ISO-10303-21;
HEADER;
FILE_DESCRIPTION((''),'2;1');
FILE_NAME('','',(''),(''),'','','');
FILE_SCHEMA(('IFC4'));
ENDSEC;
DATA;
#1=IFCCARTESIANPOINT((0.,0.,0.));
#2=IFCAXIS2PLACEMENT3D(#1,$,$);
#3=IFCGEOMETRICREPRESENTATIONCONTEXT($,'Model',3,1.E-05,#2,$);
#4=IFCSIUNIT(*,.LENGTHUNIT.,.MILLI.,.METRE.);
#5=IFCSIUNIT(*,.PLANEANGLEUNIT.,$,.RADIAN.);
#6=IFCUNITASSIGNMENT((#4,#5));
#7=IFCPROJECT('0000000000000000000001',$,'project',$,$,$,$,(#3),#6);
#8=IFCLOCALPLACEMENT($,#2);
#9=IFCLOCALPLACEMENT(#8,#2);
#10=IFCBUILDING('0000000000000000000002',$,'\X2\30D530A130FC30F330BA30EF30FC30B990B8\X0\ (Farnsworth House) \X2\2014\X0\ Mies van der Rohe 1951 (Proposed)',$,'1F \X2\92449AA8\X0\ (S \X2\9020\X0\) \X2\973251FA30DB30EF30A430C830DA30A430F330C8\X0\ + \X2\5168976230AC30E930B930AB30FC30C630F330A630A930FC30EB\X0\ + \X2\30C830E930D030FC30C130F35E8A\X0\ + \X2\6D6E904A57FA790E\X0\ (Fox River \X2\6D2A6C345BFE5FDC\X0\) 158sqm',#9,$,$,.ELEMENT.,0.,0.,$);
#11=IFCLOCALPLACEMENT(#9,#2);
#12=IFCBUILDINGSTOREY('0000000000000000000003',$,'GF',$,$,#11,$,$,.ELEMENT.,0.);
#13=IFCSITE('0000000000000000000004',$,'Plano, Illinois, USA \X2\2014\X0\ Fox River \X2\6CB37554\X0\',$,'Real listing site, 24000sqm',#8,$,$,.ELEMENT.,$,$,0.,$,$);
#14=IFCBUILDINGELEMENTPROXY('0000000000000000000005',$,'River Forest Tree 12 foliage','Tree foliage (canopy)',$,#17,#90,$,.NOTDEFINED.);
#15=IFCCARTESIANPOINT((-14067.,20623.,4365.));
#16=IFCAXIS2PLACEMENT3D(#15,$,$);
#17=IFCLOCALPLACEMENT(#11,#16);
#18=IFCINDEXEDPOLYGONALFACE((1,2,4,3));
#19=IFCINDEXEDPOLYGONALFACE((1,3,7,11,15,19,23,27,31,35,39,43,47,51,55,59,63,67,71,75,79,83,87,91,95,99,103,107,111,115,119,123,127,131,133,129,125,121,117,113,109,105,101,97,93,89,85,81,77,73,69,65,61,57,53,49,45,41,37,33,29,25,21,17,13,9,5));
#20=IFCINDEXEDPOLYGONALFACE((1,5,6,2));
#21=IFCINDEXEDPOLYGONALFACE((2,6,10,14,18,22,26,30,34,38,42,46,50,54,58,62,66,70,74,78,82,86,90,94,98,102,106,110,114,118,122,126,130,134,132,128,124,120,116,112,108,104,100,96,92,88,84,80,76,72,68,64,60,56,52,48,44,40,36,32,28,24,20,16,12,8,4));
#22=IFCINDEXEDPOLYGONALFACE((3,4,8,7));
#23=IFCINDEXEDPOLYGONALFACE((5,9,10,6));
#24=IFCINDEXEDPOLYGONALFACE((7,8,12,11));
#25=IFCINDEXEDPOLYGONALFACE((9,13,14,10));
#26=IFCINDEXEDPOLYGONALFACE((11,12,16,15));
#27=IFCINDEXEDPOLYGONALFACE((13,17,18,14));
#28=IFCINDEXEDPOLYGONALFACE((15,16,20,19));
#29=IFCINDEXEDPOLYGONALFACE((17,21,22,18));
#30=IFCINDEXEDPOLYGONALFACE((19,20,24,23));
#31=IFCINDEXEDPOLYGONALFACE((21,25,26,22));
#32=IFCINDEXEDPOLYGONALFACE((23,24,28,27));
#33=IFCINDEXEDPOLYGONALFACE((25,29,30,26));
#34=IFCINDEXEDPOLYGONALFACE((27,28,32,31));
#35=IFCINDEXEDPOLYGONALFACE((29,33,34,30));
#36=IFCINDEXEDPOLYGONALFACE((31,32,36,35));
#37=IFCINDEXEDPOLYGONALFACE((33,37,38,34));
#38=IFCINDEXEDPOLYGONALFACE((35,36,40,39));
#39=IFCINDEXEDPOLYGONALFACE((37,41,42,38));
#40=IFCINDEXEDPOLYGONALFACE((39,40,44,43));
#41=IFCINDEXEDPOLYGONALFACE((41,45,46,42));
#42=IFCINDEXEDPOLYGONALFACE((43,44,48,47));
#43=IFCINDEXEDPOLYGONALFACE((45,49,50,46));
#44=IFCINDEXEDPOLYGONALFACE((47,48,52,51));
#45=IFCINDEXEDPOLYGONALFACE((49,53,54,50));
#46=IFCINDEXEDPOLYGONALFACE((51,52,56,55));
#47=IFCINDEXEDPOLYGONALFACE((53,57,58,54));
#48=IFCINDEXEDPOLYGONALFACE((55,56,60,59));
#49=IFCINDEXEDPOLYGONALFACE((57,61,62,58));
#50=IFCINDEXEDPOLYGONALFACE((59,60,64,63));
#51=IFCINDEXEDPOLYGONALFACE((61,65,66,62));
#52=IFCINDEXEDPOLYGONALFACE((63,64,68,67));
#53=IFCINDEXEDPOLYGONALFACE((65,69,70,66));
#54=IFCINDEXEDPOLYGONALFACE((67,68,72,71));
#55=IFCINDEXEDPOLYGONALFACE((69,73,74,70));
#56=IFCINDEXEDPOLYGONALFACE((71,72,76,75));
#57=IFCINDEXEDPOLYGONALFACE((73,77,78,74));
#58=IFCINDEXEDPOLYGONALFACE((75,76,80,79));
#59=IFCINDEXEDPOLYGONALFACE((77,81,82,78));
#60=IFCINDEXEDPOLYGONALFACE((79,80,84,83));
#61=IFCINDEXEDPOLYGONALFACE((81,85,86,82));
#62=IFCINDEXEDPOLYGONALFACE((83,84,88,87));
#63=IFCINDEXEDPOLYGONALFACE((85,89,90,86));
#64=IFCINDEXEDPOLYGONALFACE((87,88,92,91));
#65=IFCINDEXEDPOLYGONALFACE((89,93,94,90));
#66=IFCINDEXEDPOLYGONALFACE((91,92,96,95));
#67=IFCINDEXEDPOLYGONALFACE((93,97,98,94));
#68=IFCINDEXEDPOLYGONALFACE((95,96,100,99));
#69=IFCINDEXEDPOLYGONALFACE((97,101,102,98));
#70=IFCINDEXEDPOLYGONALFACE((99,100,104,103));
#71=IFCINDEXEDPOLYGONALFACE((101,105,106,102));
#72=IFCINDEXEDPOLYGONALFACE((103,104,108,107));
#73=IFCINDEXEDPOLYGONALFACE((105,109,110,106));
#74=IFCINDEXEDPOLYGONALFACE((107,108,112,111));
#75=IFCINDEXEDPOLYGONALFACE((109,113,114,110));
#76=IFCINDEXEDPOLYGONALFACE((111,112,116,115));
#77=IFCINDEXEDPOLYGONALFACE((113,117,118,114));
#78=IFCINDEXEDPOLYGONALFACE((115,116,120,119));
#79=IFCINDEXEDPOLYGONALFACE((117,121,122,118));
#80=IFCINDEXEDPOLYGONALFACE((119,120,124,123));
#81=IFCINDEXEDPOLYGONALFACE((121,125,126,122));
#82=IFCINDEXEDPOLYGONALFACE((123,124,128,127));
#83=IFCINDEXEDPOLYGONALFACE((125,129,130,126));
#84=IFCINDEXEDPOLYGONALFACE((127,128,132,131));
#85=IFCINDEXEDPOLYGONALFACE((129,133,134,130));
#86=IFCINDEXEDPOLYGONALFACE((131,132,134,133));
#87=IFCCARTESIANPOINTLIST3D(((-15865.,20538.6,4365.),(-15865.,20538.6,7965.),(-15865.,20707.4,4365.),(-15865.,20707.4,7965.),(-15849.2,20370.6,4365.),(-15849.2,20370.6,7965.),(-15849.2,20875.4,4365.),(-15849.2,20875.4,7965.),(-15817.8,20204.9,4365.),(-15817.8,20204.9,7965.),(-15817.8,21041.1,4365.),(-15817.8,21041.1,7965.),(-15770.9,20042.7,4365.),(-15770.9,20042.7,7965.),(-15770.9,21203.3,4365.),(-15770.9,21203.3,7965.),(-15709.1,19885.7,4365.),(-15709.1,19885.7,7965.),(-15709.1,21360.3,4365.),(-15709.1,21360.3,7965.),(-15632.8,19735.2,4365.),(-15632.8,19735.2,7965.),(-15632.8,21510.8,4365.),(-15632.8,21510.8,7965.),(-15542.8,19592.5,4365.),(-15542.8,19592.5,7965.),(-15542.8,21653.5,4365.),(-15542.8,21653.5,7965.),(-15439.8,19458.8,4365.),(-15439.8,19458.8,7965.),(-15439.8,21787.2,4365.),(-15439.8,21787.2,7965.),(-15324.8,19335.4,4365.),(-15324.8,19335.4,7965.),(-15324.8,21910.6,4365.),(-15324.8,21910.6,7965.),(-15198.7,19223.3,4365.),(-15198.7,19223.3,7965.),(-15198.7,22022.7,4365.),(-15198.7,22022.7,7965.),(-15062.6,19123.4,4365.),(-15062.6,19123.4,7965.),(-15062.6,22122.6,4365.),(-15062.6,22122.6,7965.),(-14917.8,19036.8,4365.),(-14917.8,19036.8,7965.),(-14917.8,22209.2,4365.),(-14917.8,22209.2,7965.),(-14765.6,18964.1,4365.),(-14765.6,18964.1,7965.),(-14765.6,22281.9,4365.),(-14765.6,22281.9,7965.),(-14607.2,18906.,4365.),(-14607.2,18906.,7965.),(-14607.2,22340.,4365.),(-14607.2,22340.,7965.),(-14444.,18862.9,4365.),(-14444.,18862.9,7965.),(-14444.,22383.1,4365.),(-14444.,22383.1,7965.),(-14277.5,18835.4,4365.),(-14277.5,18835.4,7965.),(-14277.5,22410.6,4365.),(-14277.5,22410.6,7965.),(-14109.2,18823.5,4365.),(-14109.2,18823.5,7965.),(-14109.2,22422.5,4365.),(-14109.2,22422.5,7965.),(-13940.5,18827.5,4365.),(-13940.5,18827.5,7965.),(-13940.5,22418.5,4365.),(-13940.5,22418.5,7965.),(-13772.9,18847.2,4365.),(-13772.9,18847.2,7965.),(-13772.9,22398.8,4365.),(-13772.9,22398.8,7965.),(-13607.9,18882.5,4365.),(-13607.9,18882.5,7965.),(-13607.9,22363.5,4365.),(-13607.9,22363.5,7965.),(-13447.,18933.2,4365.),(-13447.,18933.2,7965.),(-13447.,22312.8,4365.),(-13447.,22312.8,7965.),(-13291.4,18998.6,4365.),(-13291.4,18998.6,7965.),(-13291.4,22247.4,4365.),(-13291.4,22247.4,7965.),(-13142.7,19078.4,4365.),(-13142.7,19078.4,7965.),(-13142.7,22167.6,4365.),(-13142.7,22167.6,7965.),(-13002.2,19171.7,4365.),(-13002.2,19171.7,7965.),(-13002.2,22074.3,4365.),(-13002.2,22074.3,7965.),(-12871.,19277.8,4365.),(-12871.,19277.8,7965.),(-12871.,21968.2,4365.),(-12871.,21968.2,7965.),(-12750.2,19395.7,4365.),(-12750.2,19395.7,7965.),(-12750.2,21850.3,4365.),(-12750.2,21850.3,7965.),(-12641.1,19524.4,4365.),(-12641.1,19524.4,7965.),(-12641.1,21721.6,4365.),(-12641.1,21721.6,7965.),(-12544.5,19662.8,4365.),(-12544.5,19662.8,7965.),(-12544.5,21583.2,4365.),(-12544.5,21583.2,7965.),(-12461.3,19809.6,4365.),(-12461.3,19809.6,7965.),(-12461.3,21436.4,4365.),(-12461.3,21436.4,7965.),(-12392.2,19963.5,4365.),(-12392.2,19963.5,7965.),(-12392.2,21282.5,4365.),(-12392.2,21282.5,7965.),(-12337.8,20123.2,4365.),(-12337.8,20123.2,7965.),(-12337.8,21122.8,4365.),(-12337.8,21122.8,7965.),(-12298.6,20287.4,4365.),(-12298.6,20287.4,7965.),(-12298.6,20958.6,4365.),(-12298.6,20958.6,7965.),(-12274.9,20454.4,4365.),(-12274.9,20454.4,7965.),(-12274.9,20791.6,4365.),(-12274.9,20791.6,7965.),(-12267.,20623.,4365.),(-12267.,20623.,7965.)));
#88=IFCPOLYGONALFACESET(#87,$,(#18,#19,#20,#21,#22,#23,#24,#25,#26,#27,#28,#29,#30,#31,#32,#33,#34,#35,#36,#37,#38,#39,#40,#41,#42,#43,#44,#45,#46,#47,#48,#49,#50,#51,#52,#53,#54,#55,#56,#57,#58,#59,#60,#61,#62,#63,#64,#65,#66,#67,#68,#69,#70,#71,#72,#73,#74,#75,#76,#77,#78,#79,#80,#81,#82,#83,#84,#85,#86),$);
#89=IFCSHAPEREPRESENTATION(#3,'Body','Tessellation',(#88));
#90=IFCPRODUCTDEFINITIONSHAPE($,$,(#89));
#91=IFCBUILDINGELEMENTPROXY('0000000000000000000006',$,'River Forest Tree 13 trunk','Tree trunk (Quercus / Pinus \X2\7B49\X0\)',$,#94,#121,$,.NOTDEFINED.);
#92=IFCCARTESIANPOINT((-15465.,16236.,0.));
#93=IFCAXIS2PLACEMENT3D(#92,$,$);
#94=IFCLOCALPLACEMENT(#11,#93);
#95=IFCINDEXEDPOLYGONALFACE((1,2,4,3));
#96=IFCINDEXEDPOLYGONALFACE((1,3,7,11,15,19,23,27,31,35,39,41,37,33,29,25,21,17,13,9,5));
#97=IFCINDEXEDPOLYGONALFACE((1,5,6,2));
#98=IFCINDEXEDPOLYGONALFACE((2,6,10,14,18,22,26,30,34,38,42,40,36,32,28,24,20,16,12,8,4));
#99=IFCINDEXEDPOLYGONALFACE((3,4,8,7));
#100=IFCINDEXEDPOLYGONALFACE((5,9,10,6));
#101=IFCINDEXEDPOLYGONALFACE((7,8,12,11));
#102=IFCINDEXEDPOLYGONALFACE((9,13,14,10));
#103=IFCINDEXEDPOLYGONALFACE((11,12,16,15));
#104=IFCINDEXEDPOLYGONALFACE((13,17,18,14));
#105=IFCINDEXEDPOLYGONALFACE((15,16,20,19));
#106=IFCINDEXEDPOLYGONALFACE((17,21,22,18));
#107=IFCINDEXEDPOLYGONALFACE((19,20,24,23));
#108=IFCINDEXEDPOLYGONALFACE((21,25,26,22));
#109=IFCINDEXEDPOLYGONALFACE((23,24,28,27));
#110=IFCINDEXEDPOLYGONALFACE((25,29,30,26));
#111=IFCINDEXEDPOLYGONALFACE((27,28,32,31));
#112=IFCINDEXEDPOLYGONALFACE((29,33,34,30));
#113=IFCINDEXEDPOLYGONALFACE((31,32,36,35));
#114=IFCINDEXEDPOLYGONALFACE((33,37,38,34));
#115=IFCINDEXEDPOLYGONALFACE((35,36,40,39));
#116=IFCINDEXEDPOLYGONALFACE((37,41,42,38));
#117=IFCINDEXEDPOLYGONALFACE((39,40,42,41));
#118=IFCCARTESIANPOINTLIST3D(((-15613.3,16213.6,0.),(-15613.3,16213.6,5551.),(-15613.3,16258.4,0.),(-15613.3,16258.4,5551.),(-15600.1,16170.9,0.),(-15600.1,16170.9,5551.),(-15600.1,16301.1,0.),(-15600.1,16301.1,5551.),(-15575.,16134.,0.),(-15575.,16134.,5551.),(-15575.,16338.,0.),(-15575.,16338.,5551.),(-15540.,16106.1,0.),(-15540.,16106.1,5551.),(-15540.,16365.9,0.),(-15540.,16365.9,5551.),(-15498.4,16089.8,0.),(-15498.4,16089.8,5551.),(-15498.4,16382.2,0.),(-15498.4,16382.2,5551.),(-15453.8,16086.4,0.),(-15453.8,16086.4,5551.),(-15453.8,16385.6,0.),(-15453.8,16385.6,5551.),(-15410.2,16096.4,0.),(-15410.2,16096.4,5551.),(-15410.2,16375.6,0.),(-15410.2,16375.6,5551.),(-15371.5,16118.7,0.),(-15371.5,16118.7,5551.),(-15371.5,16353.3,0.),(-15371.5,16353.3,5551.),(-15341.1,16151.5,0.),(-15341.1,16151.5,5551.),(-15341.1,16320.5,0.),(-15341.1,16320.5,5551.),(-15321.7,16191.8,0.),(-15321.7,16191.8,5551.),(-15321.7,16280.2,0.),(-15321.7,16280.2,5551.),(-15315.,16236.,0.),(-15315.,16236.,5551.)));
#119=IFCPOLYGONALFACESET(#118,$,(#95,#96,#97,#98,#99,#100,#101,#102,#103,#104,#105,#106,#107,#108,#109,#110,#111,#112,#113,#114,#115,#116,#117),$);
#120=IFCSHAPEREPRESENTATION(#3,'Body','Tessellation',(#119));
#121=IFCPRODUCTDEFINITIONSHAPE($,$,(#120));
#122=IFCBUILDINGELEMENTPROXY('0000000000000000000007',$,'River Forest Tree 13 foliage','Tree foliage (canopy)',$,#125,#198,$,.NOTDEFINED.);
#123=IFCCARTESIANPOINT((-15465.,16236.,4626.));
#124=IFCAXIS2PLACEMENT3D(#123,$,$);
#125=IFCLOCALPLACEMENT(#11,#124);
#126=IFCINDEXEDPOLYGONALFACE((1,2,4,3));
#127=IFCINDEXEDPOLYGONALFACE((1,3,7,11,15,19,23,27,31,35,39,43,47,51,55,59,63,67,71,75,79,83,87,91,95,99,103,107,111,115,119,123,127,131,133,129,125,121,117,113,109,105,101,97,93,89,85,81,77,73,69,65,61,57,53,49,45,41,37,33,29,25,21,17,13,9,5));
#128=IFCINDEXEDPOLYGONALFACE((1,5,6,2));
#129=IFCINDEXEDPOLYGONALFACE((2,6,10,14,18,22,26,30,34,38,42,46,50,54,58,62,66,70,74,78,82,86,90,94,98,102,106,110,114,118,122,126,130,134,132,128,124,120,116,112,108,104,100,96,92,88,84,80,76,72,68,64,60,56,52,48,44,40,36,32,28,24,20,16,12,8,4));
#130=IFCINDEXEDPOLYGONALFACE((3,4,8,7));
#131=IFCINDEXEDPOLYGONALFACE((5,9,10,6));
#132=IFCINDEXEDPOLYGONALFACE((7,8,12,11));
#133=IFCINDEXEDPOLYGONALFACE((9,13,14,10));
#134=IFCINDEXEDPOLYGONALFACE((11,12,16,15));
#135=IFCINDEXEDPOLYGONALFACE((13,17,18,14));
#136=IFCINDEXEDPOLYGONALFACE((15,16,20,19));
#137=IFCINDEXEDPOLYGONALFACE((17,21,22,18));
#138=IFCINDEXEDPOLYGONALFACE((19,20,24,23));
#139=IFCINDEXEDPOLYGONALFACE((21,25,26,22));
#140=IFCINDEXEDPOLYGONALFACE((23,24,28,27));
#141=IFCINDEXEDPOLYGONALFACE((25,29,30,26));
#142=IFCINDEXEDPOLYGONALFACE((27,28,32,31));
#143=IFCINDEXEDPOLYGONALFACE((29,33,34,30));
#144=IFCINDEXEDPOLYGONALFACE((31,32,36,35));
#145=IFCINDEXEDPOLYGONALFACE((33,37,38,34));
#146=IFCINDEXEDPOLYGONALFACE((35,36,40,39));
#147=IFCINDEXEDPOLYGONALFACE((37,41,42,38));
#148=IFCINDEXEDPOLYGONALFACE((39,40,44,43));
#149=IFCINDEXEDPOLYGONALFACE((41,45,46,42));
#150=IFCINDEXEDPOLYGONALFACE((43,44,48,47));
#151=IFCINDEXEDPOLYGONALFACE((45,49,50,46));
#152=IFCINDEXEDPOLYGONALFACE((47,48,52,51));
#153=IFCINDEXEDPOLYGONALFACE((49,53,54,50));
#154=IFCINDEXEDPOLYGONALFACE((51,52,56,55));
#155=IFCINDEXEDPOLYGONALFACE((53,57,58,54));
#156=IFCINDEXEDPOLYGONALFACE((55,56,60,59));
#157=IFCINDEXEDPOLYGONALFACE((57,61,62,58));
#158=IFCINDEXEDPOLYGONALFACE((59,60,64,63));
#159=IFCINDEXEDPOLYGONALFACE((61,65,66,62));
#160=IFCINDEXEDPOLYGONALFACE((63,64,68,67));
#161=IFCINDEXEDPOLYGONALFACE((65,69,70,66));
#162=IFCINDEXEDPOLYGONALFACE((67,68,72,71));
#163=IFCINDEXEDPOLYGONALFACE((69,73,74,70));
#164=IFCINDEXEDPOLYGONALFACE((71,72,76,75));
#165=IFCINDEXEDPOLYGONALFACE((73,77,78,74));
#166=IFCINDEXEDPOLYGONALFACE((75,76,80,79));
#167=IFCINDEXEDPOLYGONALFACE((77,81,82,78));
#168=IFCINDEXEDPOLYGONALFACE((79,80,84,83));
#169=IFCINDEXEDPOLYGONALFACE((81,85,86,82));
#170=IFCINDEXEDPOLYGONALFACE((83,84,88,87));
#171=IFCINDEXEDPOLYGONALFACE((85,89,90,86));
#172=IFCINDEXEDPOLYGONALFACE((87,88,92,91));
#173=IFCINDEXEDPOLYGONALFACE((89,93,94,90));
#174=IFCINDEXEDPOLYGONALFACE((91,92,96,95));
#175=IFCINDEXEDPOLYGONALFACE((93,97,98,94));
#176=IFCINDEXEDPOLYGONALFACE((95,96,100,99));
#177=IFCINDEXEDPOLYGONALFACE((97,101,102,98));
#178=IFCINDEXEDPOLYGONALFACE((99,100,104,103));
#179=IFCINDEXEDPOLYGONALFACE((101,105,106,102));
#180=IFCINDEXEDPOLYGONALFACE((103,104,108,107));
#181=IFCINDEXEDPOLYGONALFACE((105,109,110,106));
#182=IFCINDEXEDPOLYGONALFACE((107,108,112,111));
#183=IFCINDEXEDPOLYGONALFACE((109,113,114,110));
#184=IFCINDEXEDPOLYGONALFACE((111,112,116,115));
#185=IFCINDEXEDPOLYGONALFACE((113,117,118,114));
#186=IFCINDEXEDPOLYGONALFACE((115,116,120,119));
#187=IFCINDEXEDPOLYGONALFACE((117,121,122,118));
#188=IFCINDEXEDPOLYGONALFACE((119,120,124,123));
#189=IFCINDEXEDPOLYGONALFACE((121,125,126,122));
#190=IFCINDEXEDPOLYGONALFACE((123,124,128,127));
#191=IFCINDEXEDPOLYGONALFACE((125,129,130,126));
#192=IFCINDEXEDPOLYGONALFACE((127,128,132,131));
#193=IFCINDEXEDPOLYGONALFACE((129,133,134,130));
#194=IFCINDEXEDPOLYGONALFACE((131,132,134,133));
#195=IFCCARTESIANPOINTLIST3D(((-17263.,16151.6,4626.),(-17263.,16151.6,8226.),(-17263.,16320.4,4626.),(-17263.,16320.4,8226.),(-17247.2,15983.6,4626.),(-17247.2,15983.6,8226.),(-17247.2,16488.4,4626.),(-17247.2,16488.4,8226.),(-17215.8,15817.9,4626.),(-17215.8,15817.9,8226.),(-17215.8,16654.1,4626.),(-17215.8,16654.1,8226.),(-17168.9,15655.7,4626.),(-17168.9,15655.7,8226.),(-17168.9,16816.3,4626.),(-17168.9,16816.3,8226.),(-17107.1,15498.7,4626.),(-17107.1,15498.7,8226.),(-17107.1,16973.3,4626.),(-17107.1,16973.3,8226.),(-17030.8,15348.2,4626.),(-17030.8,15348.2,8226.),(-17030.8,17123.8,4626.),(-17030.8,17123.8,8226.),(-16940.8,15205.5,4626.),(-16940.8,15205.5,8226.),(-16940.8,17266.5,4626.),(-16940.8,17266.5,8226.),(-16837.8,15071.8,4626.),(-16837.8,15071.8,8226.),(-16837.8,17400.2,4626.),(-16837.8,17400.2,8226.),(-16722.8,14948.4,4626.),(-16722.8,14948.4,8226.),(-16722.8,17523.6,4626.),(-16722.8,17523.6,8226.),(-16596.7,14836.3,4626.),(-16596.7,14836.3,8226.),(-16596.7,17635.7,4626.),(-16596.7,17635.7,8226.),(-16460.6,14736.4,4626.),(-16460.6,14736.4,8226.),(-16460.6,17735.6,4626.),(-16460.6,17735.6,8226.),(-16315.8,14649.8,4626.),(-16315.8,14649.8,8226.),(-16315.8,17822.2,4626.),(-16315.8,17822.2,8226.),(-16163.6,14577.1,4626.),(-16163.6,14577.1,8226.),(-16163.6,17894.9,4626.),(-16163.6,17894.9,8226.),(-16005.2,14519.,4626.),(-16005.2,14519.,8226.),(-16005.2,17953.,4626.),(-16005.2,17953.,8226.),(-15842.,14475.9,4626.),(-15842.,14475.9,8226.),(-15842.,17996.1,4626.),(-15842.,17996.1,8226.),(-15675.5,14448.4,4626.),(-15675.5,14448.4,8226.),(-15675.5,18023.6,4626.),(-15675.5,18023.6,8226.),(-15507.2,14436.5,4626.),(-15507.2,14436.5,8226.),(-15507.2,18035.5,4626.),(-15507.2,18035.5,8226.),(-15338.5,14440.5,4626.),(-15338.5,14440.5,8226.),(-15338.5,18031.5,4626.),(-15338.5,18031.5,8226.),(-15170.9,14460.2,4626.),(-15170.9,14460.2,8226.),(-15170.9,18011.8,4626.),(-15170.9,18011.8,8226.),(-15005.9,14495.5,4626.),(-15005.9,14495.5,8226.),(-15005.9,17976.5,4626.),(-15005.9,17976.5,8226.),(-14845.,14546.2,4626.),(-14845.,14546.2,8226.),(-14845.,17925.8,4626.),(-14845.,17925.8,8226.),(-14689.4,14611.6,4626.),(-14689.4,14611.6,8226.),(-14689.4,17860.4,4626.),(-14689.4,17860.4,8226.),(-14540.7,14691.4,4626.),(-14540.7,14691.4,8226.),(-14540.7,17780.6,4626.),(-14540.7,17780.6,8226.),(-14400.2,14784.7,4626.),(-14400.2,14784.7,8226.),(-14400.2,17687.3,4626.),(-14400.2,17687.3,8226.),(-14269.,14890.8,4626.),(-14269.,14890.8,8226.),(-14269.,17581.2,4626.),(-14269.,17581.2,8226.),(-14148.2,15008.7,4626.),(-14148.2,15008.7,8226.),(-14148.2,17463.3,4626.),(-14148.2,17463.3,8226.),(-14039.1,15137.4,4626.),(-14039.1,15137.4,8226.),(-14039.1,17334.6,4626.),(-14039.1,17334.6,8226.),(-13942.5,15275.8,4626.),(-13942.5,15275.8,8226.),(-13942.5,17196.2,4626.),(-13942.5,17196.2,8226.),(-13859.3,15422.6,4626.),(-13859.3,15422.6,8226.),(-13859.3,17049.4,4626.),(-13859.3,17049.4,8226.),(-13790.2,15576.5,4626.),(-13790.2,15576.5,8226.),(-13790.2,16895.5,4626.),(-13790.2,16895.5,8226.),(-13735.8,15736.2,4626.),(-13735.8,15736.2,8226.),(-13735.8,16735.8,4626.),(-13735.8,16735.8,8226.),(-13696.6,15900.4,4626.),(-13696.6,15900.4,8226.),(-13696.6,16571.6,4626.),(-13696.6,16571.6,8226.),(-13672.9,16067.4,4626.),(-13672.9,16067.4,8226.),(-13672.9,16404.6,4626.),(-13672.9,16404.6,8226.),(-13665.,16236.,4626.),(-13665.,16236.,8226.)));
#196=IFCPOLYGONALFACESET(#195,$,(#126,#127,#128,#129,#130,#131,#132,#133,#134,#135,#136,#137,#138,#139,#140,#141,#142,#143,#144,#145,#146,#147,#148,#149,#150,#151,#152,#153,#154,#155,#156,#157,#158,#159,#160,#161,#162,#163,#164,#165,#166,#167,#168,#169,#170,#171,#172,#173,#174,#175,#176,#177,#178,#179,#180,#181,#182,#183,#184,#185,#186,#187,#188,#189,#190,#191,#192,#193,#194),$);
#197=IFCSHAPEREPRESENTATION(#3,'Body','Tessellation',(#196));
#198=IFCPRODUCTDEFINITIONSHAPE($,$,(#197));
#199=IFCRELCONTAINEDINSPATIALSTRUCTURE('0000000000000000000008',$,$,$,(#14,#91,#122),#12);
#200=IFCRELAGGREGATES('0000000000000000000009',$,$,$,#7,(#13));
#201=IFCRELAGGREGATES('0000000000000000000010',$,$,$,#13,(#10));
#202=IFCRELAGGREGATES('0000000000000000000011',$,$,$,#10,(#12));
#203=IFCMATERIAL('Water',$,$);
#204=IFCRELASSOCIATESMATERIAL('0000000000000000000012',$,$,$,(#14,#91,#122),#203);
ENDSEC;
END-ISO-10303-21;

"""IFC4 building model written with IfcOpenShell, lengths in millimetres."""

from ifc_helpers import new_model, si_unit, frame, origin, origin_2d, place, context, project, spatial, circle, extrude, material, element, save


model = new_model("IFC4")

# Units and contexts
model_context = context("Model", 3, precision=1e-05, world=origin())
ifc_project = project(units=[si_unit("LENGTHUNIT", "METRE", prefix="MILLI"), si_unit("PLANEANGLEUNIT", "RADIAN")], contexts=[model_context])

# Site, building, storey
site_placement = place(None, origin())
site = spatial("IfcSite", under=ifc_project, at=site_placement, Name="Plano, Illinois, USA — Fox River 河畔", ObjectType="Real listing site, 24000sqm", CompositionType="ELEMENT", RefElevation=0.0)
building_placement = place(site_placement, origin())
building = spatial("IfcBuilding", under=site, at=building_placement, Name="ファーンズワース邸 (Farnsworth House) — Mies van der Rohe 1951 (Proposed)", ObjectType="1F 鉄骨 (S 造) 露出ホワイトペイント + 全面ガラスカーテンウォール + トラバーチン床 + 浮遊基礎 (Fox River 洪水対応) 158sqm", CompositionType="ELEMENT", ElevationOfRefHeight=0.0, ElevationOfTerrain=0.0)
storey_placement = place(building_placement, origin())
storey = spatial("IfcBuildingStorey", under=building, at=storey_placement, Name="GF", CompositionType="ELEMENT", Elevation=0.0)

# Building element proxies
ifc_material_1 = material(Name="Water")
proxy_1_placement = place(storey_placement, frame((-14067.0, 20623.0, 4365.0)))
element("IfcBuildingElementProxy", 1, at=proxy_1_placement, inside=storey, material=ifc_material_1, Name="River Forest Tree 12 foliage", Description="Tree foliage (canopy)", PredefinedType="NOTDEFINED", context=model_context, shape_type="SweptSolid", body=[
    extrude(circle(Radius=1800.0, at=origin_2d()), frame((-14067.0, 20623.0, 4365.0)), (0.0, 0.0, 1.0), 3600.0),
])
proxy_2_placement = place(storey_placement, frame((-15465.0, 16236.0, 0.0)))
element("IfcBuildingElementProxy", 2, at=proxy_2_placement, inside=storey, material=ifc_material_1, Name="River Forest Tree 13 trunk", Description="Tree trunk (Quercus / Pinus 等)", PredefinedType="NOTDEFINED", context=model_context, shape_type="SweptSolid", body=[
    extrude(circle(Radius=150.0, at=origin_2d()), frame((-15465.0, 16236.0, 0.0)), (0.0, 0.0, 1.0), 5551.0),
])
proxy_3_placement = place(storey_placement, frame((-15465.0, 16236.0, 4626.0)))
element("IfcBuildingElementProxy", 3, at=proxy_3_placement, inside=storey, material=ifc_material_1, Name="River Forest Tree 13 foliage", Description="Tree foliage (canopy)", PredefinedType="NOTDEFINED", context=model_context, shape_type="SweptSolid", body=[
    extrude(circle(Radius=1800.0, at=origin_2d()), frame((-15465.0, 16236.0, 4626.0)), (0.0, 0.0, 1.0), 3600.0),
])

save(model, "model.ifc")
